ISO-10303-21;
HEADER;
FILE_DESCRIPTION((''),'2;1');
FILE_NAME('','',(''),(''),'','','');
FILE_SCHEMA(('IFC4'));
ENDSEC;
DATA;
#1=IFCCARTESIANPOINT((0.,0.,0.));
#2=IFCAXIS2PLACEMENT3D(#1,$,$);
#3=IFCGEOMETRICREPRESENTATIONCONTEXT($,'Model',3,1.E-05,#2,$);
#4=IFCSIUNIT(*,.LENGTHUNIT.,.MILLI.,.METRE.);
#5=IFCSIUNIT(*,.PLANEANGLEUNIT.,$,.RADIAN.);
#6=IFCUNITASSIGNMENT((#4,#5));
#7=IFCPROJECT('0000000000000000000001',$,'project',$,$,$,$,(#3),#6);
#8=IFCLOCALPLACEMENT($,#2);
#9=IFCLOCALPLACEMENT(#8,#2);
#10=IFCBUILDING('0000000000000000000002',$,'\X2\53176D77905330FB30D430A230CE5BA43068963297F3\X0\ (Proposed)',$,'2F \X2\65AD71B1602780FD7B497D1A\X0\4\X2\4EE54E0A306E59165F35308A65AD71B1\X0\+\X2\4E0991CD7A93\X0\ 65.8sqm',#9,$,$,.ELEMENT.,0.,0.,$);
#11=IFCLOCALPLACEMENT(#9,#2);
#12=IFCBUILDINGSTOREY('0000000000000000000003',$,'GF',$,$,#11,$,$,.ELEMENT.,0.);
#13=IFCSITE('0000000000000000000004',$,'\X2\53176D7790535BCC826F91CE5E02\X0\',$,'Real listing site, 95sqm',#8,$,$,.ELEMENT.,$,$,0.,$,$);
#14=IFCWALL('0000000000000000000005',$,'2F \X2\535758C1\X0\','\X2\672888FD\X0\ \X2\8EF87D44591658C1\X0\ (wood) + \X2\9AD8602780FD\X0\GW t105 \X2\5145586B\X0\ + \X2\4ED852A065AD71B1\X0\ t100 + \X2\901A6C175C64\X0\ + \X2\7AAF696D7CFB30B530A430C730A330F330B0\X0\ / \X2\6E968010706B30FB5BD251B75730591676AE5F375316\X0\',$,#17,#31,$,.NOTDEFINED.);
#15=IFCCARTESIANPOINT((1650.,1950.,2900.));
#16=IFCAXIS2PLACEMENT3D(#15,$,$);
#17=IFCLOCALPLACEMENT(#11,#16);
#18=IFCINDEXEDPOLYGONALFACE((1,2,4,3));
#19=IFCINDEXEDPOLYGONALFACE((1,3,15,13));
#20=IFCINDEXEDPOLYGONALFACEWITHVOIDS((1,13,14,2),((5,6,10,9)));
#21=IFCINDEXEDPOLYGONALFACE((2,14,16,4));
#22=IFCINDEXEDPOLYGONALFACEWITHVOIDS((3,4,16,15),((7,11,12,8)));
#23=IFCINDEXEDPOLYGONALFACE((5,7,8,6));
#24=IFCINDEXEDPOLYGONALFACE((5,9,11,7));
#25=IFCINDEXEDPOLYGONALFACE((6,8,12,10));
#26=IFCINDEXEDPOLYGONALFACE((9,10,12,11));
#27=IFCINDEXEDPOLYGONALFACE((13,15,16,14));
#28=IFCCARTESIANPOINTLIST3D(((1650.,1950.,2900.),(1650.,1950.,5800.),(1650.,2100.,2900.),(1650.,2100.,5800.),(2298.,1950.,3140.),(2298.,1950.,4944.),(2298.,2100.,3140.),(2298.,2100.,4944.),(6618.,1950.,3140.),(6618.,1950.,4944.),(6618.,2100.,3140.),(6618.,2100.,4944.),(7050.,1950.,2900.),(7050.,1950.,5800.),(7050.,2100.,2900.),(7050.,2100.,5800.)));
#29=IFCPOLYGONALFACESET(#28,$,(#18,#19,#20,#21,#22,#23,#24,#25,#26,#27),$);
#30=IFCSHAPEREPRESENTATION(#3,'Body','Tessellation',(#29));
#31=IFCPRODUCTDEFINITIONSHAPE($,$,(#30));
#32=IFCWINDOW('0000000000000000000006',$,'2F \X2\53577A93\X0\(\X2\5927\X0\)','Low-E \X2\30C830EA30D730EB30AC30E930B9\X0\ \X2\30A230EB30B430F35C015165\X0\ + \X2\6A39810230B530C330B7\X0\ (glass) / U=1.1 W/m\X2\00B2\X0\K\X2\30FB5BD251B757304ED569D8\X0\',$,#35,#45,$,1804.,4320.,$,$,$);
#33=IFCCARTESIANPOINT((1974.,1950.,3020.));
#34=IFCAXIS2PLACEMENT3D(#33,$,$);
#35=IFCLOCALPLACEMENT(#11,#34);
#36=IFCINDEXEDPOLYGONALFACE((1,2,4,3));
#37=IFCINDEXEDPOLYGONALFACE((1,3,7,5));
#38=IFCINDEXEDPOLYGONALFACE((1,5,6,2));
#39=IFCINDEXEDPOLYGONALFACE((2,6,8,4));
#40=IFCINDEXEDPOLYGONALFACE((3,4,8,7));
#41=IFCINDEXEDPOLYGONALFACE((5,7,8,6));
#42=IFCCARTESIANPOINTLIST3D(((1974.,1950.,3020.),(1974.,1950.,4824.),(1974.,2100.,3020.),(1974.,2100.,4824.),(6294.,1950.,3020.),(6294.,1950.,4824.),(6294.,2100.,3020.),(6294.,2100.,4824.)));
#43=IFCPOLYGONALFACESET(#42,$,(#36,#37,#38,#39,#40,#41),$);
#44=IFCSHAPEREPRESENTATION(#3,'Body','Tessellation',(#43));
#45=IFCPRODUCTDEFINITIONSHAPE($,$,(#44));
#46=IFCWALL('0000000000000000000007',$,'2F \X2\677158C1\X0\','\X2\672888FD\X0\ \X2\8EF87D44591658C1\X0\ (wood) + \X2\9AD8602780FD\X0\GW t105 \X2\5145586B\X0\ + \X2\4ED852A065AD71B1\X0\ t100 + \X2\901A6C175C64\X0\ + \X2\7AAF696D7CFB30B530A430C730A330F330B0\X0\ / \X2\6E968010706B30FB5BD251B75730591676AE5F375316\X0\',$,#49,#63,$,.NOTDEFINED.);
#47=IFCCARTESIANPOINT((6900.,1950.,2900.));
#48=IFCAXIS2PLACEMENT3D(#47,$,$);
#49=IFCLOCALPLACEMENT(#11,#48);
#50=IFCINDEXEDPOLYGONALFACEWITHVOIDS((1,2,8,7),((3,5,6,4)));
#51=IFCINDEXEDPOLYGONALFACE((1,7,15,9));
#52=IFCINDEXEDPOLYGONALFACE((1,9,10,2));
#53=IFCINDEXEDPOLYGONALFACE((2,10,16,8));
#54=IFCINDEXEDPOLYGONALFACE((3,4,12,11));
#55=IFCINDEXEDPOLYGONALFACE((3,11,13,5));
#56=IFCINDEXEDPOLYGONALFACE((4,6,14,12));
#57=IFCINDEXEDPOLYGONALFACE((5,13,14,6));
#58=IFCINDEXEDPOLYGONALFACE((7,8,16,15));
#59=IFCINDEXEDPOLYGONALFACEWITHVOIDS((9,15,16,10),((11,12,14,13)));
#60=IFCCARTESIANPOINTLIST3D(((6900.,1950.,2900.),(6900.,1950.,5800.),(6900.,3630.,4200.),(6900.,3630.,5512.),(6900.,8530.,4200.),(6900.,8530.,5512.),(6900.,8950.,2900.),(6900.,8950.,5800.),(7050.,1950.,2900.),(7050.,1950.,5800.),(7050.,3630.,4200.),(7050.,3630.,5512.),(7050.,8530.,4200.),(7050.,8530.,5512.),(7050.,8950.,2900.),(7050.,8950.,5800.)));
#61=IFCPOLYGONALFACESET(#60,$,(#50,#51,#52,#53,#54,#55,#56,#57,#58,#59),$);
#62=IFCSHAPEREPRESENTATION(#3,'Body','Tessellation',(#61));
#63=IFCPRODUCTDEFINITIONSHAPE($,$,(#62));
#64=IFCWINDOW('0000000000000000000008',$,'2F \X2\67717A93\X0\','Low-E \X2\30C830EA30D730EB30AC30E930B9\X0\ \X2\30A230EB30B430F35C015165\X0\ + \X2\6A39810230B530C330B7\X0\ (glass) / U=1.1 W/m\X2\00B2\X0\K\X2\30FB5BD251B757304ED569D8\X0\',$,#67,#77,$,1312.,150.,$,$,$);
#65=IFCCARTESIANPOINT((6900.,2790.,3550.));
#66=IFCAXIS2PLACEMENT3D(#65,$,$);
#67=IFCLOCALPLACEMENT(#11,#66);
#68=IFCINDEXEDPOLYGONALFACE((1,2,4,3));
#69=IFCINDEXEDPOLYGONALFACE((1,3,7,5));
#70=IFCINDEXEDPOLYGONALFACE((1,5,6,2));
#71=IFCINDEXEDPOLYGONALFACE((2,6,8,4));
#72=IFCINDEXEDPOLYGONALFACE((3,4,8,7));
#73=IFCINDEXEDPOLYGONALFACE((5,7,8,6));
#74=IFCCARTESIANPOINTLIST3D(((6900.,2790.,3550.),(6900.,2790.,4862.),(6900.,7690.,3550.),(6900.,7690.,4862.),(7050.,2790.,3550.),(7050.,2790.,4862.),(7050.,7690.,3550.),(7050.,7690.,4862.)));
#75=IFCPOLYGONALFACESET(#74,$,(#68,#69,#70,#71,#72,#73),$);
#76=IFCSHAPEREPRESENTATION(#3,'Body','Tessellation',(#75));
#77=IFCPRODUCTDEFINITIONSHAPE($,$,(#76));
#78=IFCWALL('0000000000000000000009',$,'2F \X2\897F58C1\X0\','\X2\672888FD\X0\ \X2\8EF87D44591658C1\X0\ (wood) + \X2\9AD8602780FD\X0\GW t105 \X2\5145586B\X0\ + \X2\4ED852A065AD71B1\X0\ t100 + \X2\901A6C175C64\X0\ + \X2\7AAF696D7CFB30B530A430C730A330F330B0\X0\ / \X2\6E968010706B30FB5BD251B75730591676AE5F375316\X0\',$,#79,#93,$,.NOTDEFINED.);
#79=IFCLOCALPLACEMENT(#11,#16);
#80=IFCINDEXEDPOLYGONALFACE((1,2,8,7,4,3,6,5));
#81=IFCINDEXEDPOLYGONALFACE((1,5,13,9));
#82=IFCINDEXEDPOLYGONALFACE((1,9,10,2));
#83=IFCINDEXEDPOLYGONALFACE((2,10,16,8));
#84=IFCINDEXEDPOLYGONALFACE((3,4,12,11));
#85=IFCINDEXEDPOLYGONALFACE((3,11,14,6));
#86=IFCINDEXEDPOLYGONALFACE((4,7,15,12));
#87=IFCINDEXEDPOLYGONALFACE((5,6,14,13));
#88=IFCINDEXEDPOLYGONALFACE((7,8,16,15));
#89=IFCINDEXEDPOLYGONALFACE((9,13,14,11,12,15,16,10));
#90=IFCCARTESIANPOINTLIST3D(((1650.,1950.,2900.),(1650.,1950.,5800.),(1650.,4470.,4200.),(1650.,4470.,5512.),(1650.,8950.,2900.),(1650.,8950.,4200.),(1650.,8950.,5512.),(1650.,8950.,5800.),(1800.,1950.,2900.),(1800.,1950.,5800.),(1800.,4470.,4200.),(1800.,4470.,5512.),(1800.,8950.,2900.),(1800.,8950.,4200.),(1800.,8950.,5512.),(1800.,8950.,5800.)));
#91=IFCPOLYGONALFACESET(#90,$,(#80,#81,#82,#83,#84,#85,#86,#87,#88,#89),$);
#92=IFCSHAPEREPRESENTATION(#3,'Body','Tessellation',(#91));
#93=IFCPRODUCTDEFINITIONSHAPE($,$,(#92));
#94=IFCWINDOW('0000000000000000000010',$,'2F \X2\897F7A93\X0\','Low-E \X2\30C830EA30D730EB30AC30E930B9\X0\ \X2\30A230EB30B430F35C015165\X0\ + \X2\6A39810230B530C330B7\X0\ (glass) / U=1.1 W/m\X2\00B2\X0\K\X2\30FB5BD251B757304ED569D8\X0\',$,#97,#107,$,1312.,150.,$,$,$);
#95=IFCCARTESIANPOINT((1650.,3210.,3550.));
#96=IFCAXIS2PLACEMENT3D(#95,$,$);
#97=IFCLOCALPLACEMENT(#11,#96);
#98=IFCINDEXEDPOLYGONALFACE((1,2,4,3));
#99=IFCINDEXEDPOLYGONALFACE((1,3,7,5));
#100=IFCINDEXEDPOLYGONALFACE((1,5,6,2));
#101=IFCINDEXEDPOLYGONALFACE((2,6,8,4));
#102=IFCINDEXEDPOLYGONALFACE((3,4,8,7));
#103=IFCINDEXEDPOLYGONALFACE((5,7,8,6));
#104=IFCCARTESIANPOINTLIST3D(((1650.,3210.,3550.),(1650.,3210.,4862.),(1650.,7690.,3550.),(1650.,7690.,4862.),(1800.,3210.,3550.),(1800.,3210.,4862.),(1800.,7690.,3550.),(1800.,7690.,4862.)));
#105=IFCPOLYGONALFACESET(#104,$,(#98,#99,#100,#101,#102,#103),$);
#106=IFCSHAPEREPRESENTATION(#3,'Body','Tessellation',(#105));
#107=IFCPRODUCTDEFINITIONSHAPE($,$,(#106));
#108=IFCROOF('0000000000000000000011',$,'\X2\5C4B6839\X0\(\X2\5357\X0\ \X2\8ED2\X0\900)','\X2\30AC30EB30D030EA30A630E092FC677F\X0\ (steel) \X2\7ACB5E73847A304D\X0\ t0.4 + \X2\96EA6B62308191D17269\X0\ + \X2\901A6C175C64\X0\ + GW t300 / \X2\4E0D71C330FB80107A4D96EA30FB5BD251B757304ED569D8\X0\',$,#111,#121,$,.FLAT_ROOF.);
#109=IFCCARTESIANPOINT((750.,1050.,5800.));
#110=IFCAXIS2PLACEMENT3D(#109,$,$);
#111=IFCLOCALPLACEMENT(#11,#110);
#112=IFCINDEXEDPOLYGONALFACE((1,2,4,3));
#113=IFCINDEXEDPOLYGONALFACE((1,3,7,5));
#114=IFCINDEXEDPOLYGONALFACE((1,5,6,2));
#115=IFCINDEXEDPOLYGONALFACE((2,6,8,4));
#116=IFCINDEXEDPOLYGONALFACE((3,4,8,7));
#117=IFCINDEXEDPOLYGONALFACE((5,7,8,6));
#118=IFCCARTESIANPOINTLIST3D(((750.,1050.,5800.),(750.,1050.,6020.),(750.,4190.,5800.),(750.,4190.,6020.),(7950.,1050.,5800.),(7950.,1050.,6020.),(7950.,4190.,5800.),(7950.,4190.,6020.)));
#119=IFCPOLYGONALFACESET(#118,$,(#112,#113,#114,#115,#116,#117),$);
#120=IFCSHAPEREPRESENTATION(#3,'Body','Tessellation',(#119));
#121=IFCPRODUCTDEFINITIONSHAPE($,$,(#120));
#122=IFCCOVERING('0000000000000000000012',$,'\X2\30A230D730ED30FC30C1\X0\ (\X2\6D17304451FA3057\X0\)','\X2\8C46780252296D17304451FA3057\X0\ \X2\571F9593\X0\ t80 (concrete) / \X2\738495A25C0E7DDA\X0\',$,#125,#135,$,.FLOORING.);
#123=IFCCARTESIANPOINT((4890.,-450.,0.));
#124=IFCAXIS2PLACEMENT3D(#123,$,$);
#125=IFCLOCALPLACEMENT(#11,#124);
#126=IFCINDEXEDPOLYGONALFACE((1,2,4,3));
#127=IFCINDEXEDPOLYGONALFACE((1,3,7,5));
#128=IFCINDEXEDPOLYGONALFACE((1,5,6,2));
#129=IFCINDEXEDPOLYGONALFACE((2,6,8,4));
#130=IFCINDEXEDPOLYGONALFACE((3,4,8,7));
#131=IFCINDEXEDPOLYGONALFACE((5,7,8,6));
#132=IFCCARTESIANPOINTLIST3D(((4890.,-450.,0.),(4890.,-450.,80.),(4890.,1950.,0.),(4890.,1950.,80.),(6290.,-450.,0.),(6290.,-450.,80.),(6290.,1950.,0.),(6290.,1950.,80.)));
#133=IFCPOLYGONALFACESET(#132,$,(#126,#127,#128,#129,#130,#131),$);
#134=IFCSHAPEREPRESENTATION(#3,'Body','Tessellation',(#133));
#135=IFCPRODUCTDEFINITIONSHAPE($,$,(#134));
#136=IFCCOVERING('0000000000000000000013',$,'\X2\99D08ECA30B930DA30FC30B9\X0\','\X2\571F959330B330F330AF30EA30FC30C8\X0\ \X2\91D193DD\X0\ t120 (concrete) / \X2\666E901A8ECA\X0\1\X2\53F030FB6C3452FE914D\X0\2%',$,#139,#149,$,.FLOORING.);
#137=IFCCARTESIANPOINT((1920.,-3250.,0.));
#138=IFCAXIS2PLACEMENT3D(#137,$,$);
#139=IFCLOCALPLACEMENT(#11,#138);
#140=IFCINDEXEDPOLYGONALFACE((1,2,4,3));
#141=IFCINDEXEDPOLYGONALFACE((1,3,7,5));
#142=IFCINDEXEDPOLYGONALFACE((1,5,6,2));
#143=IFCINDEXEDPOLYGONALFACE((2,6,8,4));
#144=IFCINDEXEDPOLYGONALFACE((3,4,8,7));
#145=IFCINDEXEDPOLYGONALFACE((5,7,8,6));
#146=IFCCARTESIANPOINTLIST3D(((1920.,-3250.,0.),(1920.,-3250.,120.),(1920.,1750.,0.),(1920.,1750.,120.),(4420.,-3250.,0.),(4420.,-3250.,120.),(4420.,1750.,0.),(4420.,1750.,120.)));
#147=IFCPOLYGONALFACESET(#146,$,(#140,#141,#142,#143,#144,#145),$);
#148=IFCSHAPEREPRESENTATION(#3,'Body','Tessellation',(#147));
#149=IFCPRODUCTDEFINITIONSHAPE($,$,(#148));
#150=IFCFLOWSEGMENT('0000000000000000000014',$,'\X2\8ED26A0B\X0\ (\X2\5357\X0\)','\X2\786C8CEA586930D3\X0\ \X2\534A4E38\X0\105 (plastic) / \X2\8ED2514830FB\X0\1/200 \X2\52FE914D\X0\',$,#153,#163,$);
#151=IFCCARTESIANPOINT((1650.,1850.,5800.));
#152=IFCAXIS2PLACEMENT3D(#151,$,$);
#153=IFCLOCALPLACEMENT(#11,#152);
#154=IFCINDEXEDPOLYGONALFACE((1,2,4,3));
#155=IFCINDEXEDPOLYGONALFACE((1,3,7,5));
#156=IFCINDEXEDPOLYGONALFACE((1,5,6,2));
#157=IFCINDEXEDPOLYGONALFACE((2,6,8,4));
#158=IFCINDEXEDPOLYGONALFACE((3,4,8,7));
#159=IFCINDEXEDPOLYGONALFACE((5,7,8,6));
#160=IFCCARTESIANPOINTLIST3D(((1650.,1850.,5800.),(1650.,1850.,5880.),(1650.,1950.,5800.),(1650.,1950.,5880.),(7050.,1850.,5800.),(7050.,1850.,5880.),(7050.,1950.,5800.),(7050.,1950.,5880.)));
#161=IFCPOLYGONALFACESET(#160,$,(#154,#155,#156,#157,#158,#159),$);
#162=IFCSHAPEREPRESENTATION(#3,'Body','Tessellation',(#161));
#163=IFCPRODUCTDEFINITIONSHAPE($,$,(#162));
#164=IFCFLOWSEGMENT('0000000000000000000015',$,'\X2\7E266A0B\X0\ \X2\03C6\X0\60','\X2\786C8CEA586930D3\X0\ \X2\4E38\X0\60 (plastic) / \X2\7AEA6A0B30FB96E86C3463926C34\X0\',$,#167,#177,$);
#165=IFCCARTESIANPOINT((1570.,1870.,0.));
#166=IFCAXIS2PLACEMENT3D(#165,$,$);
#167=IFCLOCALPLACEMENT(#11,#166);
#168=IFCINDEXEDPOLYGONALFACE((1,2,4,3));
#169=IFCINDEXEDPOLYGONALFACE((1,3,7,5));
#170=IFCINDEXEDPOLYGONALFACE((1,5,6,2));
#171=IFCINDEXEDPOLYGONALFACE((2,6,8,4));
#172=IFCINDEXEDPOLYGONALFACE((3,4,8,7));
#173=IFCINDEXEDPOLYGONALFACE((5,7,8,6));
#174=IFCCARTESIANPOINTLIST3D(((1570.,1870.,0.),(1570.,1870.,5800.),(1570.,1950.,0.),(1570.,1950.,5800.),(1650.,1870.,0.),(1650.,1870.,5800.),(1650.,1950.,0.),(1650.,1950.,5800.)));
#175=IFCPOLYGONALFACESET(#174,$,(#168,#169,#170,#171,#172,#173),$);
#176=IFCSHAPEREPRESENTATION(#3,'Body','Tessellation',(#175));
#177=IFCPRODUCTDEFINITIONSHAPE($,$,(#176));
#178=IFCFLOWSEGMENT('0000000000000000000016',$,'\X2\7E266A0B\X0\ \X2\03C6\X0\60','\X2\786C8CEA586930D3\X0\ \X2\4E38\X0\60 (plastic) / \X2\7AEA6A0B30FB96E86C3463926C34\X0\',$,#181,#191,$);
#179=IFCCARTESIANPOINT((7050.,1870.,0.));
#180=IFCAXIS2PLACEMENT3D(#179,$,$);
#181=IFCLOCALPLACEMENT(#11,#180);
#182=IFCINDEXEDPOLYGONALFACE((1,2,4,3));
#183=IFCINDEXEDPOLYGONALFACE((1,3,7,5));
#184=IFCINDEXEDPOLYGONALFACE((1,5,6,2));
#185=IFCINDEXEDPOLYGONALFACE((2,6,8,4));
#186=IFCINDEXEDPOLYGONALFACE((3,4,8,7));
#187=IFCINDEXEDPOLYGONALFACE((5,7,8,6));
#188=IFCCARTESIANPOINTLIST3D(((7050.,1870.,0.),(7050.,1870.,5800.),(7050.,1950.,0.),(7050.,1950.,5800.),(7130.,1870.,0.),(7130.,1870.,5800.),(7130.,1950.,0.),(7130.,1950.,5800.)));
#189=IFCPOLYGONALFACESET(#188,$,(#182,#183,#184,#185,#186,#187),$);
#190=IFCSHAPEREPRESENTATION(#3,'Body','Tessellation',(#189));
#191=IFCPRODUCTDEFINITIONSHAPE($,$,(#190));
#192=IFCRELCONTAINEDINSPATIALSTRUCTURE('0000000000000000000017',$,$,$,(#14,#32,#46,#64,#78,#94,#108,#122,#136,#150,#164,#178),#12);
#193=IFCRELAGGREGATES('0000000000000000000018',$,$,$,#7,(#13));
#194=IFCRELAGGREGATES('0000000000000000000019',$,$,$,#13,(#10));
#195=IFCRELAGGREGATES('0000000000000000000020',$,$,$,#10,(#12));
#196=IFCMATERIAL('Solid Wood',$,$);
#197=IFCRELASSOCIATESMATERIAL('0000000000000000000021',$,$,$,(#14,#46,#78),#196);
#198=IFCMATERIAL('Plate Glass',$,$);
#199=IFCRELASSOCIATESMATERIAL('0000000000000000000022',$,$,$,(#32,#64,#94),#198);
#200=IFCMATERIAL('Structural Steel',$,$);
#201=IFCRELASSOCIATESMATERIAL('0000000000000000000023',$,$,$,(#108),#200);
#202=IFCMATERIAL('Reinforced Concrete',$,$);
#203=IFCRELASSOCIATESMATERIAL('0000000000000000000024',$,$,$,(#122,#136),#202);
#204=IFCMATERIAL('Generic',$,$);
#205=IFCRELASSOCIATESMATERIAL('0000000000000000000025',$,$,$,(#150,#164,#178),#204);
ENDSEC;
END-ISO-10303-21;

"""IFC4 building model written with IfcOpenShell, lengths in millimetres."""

from ifc_helpers import new_model, si_unit, frame, frame_2d, origin, place, context, project, spatial, rectangle, extrude, material, element, fill, save


model = new_model("IFC4")

# Units and contexts
model_context = context("Model", 3, precision=1e-05, world=origin())
ifc_project = project(units=[si_unit("LENGTHUNIT", "METRE", prefix="MILLI"), si_unit("PLANEANGLEUNIT", "RADIAN")], contexts=[model_context])

# Site, building, storey
site_placement = place(None, origin())
site = spatial("IfcSite", under=ifc_project, at=site_placement, Name="北海道富良野市", ObjectType="Real listing site, 95sqm", CompositionType="ELEMENT", RefElevation=0.0)
building_placement = place(site_placement, origin())
building = spatial("IfcBuilding", under=site, at=building_placement, Name="北海道・ピアノ室と防音 (Proposed)", ObjectType="2F 断熱性能等級4以上の外張り断熱+三重窓 65.8sqm", CompositionType="ELEMENT", ElevationOfRefHeight=0.0, ElevationOfTerrain=0.0)
storey_placement = place(building_placement, origin())
storey = spatial("IfcBuildingStorey", under=building, at=storey_placement, Name="GF", CompositionType="ELEMENT", Elevation=0.0)

# Shared definitions
ifc_material_1 = material(Name="Solid Wood")

# Shared definitions
ifc_material_2 = material(Name="Reinforced Concrete")

# Shared definitions
ifc_material_3 = material(Name="Plate Glass")

# Walls, openings, windows
wall_1_placement = place(storey_placement, frame((1650.0, 1950.0, 2900.0)))
wall_1 = element("IfcWall", 1, at=wall_1_placement, inside=storey, material=ifc_material_1, Name="2F 南壁", Description="木製 軸組外壁 (wood) + 高性能GW t105 充填 + 付加断熱 t100 + 通気層 + 窯業系サイディング / 準耐火・寒冷地外皮強化", PredefinedType="NOTDEFINED", context=model_context, shape_type="SweptSolid", body=[
    extrude(rectangle(XDim=5400.0, YDim=150.0, at=frame_2d((2700.0, 75.0))), frame((1650.0, 1950.0, 2900.0)), (0.0, 0.0, 1.0), 2900.0),
])
opening_1_placement = place(storey_placement, frame((1974.0, 1950.0, 3020.0)))
opening_1 = element("IfcOpeningElement", 2, at=opening_1_placement, cuts=wall_1, PredefinedType="NOTDEFINED", context=model_context, shape_type="SweptSolid", body=[
    extrude(rectangle(XDim=4320.0, YDim=150.0, at=frame_2d((2160.0, 75.0))), frame((1974.0, 1950.0, 3020.0)), (0.0, 0.0, 1.0), 1804.0),
])
window_1_placement = place(storey_placement, frame((1974.0, 1950.0, 3020.0)))
window_1 = element("IfcWindow", 3, at=window_1_placement, inside=storey, material=ifc_material_3, Name="2F 南窓(大)", Description="Low-E トリプルガラス アルゴン封入 + 樹脂サッシ (glass) / U=1.1 W/m²K・寒冷地仕様", OverallHeight=1804.0, OverallWidth=4320.0, context=model_context, shape_type="SweptSolid", body=[
    extrude(rectangle(XDim=4320.0, YDim=150.0, at=frame_2d((2160.0, 75.0))), frame((1974.0, 1950.0, 3020.0)), (0.0, 0.0, 1.0), 1804.0),
])
fill(opening_1, window_1)
wall_2_placement = place(storey_placement, frame((6900.0, 1950.0, 2900.0)))
wall_2 = element("IfcWall", 4, at=wall_2_placement, inside=storey, material=ifc_material_1, Name="2F 東壁", Description="木製 軸組外壁 (wood) + 高性能GW t105 充填 + 付加断熱 t100 + 通気層 + 窯業系サイディング / 準耐火・寒冷地外皮強化", PredefinedType="NOTDEFINED", context=model_context, shape_type="SweptSolid", body=[
    extrude(rectangle(XDim=150.0, YDim=7000.0, at=frame_2d((75.0, 3500.0))), frame((6900.0, 1950.0, 2900.0)), (0.0, 0.0, 1.0), 2900.0),
])
opening_2_placement = place(storey_placement, frame((6900.0, 2790.0, 3550.0)))
opening_2 = element("IfcOpeningElement", 5, at=opening_2_placement, cuts=wall_2, PredefinedType="NOTDEFINED", context=model_context, shape_type="SweptSolid", body=[
    extrude(rectangle(XDim=150.0, YDim=4900.0, at=frame_2d((75.0, 2450.0))), frame((6900.0, 2790.0, 3550.0)), (0.0, 0.0, 1.0), 1312.0),
])
window_2_placement = place(storey_placement, frame((6900.0, 2790.0, 3550.0)))
window_2 = element("IfcWindow", 6, at=window_2_placement, inside=storey, material=ifc_material_3, Name="2F 東窓", Description="Low-E トリプルガラス アルゴン封入 + 樹脂サッシ (glass) / U=1.1 W/m²K・寒冷地仕様", OverallHeight=1312.0, OverallWidth=150.0, context=model_context, shape_type="SweptSolid", body=[
    extrude(rectangle(XDim=150.0, YDim=4900.0, at=frame_2d((75.0, 2450.0))), frame((6900.0, 2790.0, 3550.0)), (0.0, 0.0, 1.0), 1312.0),
])
fill(opening_2, window_2)
wall_3_placement = place(storey_placement, frame((1650.0, 1950.0, 2900.0)))
wall_3 = element("IfcWall", 7, at=wall_3_placement, inside=storey, material=ifc_material_1, Name="2F 西壁", Description="木製 軸組外壁 (wood) + 高性能GW t105 充填 + 付加断熱 t100 + 通気層 + 窯業系サイディング / 準耐火・寒冷地外皮強化", PredefinedType="NOTDEFINED", context=model_context, shape_type="SweptSolid", body=[
    extrude(rectangle(XDim=150.0, YDim=7000.0, at=frame_2d((75.0, 3500.0))), frame((1650.0, 1950.0, 2900.0)), (0.0, 0.0, 1.0), 2900.0),
])
opening_3_placement = place(storey_placement, frame((1650.0, 3210.0, 3550.0)))
opening_3 = element("IfcOpeningElement", 8, at=opening_3_placement, cuts=wall_3, PredefinedType="NOTDEFINED", context=model_context, shape_type="SweptSolid", body=[
    extrude(rectangle(XDim=150.0, YDim=4480.0, at=frame_2d((75.0, 2240.0))), frame((1650.0, 3210.0, 3550.0)), (0.0, 0.0, 1.0), 1312.0),
])
window_3_placement = place(storey_placement, frame((1650.0, 3210.0, 3550.0)))
window_3 = element("IfcWindow", 9, at=window_3_placement, inside=storey, material=ifc_material_3, Name="2F 西窓", Description="Low-E トリプルガラス アルゴン封入 + 樹脂サッシ (glass) / U=1.1 W/m²K・寒冷地仕様", OverallHeight=1312.0, OverallWidth=150.0, context=model_context, shape_type="SweptSolid", body=[
    extrude(rectangle(XDim=150.0, YDim=4480.0, at=frame_2d((75.0, 2240.0))), frame((1650.0, 3210.0, 3550.0)), (0.0, 0.0, 1.0), 1312.0),
])
fill(opening_3, window_3)

# Roof
ifc_material_4 = material(Name="Structural Steel")
for number, where, name in (
    (10, (750.0, 1050.0, 5800.0), "屋根(南 軒900)"),
):
    element("IfcRoof", number, at=place(storey_placement, frame(where)), inside=storey, material=ifc_material_4, Name=name, Description="ガルバリウム鋼板 (steel) 立平葺き t0.4 + 雪止め金物 + 通気層 + GW t300 / 不燃・耐積雪・寒冷地仕様", PredefinedType="FLAT_ROOF", context=model_context, shape_type="SweptSolid", body=[
        extrude(rectangle(XDim=7200.0, YDim=3140.0, at=frame_2d((3600.0, 1570.0))), frame((750.0, 1050.0, 5800.0)), (0.0, 0.0, 1.0), 220.0),
    ])

# Coverings
covering_1_placement = place(storey_placement, frame((4890.0, -450.0, 0.0)))
element("IfcCovering", 11, at=covering_1_placement, inside=storey, material=ifc_material_2, Name="アプローチ (洗い出し)", Description="豆砂利洗い出し 土間 t80 (concrete) / 玄関導線", PredefinedType="FLOORING", context=model_context, shape_type="SweptSolid", body=[
    extrude(rectangle(XDim=1400.0, YDim=2400.0, at=frame_2d((700.0, 1200.0))), frame((4890.0, -450.0, 0.0)), (0.0, 0.0, 1.0), 80.0),
])
covering_2_placement = place(storey_placement, frame((1920.0, -3250.0, 0.0)))
element("IfcCovering", 12, at=covering_2_placement, inside=storey, material=ifc_material_2, Name="駐車スペース", Description="土間コンクリート 金鏝 t120 (concrete) / 普通車1台・水勾配2%", PredefinedType="FLOORING", context=model_context, shape_type="SweptSolid", body=[
    extrude(rectangle(XDim=2500.0, YDim=5000.0, at=frame_2d((1250.0, 2500.0))), frame((1920.0, -3250.0, 0.0)), (0.0, 0.0, 1.0), 120.0),
])

# Flow segments
ifc_material_5 = material(Name="Generic")
flow_segment_1_placement = place(storey_placement, frame((1650.0, 1850.0, 5800.0)))
element("IfcFlowSegment", 13, at=flow_segment_1_placement, inside=storey, material=ifc_material_5, Name="軒樋 (南)", Description="硬質塩ビ 半丸105 (plastic) / 軒先・1/200 勾配", context=model_context, shape_type="SweptSolid", body=[
    extrude(rectangle(XDim=5400.0, YDim=100.0, at=frame_2d((2700.0, 50.0))), frame((1650.0, 1850.0, 5800.0)), (0.0, 0.0, 1.0), 80.0),
])
flow_segment_2_placement = place(storey_placement, frame((1570.0, 1870.0, 0.0)))
element("IfcFlowSegment", 14, at=flow_segment_2_placement, inside=storey, material=ifc_material_5, Name="縦樋 φ60", Description="硬質塩ビ 丸60 (plastic) / 竪樋・雨水排水", context=model_context, shape_type="SweptSolid", body=[
    extrude(rectangle(XDim=80.0, YDim=80.0, at=frame_2d((40.0, 40.0))), frame((1570.0, 1870.0, 0.0)), (0.0, 0.0, 1.0), 5800.0),
])
flow_segment_3_placement = place(storey_placement, frame((7050.0, 1870.0, 0.0)))
element("IfcFlowSegment", 15, at=flow_segment_3_placement, inside=storey, material=ifc_material_5, Name="縦樋 φ60", Description="硬質塩ビ 丸60 (plastic) / 竪樋・雨水排水", context=model_context, shape_type="SweptSolid", body=[
    extrude(rectangle(XDim=80.0, YDim=80.0, at=frame_2d((40.0, 40.0))), frame((7050.0, 1870.0, 0.0)), (0.0, 0.0, 1.0), 5800.0),
])

save(model, "model.ifc")
